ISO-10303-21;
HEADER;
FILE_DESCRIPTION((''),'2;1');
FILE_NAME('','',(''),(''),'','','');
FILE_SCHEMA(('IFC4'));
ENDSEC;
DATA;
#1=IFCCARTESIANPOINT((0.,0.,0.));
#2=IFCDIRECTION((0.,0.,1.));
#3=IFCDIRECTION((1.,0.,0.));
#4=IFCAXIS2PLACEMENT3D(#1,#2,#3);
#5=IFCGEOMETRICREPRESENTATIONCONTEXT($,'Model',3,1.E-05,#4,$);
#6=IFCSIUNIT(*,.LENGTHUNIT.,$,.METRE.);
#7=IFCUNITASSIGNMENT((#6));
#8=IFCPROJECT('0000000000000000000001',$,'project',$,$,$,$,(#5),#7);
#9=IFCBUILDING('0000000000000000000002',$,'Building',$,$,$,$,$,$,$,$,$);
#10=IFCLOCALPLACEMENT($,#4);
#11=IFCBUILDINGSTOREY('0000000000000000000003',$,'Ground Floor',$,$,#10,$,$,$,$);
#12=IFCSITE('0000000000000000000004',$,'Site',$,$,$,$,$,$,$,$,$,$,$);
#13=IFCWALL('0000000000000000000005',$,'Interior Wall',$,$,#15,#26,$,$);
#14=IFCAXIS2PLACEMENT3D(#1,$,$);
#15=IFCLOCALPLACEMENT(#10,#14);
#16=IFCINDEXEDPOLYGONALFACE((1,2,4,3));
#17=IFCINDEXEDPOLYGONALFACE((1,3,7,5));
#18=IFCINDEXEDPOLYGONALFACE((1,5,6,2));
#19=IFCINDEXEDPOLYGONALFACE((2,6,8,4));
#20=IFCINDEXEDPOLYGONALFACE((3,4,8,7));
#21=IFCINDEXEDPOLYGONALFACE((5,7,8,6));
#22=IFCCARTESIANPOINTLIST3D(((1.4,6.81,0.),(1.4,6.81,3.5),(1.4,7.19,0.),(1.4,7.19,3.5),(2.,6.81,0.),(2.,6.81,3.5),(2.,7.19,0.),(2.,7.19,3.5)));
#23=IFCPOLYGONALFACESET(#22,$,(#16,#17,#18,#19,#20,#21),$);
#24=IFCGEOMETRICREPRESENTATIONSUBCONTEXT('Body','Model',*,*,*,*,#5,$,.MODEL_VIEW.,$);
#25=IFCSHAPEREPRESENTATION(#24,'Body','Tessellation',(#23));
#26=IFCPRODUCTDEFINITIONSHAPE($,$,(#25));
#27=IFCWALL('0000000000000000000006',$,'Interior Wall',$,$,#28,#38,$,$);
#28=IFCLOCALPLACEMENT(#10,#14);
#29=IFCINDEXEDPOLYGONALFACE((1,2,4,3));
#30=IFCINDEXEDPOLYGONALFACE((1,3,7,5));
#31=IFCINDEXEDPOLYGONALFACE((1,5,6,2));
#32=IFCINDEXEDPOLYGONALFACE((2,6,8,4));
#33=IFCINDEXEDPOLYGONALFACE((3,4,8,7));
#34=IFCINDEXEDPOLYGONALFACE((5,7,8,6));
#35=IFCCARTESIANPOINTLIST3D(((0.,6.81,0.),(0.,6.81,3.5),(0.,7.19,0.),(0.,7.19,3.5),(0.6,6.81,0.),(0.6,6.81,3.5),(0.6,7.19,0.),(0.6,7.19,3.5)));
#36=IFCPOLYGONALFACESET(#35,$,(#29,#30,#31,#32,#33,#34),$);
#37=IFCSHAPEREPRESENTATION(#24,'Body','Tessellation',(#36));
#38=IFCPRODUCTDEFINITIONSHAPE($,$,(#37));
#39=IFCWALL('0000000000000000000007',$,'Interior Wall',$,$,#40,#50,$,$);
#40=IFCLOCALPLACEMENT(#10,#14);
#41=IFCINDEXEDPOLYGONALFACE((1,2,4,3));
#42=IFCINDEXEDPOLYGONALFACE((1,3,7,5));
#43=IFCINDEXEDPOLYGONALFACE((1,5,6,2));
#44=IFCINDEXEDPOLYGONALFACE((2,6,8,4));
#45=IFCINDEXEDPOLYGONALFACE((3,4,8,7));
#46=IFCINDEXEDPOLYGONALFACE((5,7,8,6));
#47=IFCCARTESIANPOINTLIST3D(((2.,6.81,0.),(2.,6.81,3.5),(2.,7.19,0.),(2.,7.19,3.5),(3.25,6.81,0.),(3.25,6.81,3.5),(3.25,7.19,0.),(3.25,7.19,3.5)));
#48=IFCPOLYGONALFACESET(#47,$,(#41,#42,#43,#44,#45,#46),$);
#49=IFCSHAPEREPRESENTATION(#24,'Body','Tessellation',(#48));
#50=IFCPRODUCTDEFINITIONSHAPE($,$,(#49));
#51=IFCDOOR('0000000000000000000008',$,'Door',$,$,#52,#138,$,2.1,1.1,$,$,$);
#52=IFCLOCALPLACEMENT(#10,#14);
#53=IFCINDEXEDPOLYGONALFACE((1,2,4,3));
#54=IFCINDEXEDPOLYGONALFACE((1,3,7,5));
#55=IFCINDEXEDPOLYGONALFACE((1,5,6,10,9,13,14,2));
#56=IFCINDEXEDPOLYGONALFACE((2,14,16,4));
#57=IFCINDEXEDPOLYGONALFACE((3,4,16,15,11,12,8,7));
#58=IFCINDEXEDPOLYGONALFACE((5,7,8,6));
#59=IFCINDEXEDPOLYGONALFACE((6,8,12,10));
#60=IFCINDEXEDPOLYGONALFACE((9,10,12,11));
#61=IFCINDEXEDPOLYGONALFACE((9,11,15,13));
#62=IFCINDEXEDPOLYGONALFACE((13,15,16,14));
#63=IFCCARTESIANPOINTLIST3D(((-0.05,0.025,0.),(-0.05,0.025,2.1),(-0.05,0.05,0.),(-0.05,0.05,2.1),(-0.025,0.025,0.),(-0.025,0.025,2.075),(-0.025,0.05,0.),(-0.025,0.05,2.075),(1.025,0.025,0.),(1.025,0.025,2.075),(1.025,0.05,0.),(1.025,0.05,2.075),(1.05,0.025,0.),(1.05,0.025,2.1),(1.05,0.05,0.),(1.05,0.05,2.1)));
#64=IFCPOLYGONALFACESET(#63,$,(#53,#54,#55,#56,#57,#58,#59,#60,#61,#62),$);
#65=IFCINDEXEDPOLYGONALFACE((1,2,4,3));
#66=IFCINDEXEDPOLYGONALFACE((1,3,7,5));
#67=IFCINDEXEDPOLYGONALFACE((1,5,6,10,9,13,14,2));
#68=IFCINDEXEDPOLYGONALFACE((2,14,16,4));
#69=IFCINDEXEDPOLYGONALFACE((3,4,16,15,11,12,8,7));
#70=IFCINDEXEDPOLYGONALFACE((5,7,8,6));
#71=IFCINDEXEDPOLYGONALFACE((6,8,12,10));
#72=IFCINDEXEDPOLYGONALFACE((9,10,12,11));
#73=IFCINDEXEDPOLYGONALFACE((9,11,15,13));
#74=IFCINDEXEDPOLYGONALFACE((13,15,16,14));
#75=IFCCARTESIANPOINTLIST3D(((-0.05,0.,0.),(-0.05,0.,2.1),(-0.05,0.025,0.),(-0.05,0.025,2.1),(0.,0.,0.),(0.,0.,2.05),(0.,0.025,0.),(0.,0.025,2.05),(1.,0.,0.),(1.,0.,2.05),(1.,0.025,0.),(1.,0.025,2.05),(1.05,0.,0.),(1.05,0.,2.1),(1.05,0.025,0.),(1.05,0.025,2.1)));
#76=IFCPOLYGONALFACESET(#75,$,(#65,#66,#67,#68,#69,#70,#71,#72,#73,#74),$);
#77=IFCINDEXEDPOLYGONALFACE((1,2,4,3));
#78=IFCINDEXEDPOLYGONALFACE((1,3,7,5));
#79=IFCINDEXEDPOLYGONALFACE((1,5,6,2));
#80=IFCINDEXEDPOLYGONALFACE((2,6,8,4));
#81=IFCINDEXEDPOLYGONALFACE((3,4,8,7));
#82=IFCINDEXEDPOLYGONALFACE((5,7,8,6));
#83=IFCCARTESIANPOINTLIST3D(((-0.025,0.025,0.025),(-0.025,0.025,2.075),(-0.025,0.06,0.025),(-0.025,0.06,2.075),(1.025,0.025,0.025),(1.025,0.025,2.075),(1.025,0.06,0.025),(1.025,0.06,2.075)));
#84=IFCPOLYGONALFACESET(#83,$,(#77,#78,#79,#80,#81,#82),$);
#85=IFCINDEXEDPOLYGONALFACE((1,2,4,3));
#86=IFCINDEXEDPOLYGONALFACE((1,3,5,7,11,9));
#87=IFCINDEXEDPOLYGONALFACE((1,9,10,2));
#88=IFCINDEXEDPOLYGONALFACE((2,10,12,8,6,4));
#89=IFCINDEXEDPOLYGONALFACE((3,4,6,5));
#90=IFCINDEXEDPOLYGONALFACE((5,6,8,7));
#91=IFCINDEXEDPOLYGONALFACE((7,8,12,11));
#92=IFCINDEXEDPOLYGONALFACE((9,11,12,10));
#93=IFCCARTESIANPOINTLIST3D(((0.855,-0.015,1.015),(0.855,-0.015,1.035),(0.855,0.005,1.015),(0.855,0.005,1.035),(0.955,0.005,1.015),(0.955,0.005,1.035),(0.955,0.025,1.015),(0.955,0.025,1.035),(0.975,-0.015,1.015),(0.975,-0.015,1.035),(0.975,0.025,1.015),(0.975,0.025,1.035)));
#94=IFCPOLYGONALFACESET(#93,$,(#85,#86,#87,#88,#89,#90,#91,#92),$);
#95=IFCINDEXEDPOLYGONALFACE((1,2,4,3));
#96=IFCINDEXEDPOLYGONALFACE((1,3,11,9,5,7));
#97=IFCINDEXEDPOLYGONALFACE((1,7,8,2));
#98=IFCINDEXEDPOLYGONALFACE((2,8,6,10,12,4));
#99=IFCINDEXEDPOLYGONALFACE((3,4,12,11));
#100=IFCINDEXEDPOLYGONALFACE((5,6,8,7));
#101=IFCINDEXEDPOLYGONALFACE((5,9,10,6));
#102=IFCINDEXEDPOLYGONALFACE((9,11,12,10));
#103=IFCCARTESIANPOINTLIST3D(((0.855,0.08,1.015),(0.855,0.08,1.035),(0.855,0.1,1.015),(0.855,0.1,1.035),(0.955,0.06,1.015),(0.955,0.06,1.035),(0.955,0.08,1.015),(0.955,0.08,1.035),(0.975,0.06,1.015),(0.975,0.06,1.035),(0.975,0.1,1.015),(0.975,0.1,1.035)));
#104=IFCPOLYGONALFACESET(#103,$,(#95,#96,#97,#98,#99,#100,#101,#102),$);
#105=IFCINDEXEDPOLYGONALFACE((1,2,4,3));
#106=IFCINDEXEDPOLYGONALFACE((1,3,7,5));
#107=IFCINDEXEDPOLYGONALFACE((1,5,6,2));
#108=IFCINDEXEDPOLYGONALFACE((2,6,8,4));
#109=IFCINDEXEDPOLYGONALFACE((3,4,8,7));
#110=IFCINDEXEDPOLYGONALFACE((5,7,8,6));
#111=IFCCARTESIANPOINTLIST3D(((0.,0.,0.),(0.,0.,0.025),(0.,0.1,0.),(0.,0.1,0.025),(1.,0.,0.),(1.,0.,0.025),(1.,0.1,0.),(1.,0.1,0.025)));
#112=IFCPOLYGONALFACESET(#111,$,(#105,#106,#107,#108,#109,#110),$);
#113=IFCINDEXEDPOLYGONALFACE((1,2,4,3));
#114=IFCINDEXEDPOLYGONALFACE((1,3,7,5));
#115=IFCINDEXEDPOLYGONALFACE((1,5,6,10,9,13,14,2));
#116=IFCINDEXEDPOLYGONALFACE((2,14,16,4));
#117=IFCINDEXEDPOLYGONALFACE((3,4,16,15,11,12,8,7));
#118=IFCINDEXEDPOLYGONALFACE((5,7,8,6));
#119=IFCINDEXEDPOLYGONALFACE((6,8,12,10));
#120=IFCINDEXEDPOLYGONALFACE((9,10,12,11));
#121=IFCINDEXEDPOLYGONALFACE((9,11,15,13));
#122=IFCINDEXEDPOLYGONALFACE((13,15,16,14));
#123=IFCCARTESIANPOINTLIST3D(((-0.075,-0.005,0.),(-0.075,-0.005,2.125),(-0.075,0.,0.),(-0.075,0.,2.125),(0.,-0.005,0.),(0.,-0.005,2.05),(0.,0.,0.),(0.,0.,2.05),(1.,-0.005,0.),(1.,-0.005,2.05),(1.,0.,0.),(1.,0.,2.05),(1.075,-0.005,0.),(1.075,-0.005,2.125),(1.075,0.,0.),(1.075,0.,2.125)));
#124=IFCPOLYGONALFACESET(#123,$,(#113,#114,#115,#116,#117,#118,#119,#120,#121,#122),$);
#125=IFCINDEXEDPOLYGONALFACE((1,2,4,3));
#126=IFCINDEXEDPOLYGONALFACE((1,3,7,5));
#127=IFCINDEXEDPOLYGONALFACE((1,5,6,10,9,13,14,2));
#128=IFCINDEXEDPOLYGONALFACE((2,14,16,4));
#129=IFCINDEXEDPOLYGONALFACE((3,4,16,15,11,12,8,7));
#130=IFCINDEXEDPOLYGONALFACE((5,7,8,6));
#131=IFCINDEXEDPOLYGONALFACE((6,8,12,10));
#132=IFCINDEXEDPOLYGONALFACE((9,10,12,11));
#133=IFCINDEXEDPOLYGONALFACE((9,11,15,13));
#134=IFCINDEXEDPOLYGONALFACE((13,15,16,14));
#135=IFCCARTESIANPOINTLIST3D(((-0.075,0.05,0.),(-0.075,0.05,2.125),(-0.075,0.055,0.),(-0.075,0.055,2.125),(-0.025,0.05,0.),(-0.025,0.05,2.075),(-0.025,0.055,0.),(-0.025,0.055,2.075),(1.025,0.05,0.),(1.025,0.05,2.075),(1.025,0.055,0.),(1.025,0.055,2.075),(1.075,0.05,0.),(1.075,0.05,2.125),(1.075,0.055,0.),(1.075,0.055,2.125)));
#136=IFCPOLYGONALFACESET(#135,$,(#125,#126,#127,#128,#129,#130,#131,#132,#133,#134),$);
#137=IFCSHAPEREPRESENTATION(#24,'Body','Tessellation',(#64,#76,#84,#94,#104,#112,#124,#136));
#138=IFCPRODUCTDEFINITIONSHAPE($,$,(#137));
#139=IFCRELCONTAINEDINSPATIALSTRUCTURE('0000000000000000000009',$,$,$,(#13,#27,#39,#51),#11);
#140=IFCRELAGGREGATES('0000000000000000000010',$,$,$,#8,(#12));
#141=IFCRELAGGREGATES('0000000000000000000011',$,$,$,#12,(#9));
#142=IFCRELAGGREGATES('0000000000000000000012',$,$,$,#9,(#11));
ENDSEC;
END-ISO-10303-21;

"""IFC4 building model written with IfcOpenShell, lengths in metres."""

from ifc_helpers import new_model, si_unit, frame, origin_with_axes, place, context, subcontext, project, spatial, line, indexed_curve, outline, extrude, element, save


model = new_model("IFC4")

# Units and contexts
model_context = context("Model", 3, precision=1e-05, world=origin_with_axes())
body_context = subcontext(model_context, "Body", "Model", "MODEL_VIEW")
ifc_project = project(units=[si_unit("LENGTHUNIT", "METRE")], contexts=[model_context])

# Site, building, storey
site = spatial("IfcSite", under=ifc_project, Name="Site")
building = spatial("IfcBuilding", under=site, Name="Building")
storey_placement = place(None, origin_with_axes())
storey = spatial("IfcBuildingStorey", under=building, at=storey_placement, Name="Ground Floor")

# Walls
for number, where, z_axis, x_axis, name in (
    (1, (2.0, 7.0, 0.0), (0.0, 0.0, 1.0), (-1.0, 0.0, 0.0), "Interior Wall"),
    (2, (0.6, 7.0, 0.0), (0.0, 0.0, 1.0), (-1.0, 0.0, 0.0), "Interior Wall"),
):
    element("IfcWall", number, at=place(storey_placement, frame(where, z_axis=z_axis, x_axis=x_axis)), inside=storey, Name=name, context=body_context, shape_type="SweptSolid", body=[
        extrude(outline(indexed_curve([(0.0, 0.0), (0.0, 0.38), (0.6, 0.38), (0.6, 0.0), (0.0, 0.0)], self_intersect=False)), frame((0.0, -0.19, 0.0), z_axis=(0.0, 0.0, 1.0), x_axis=(1.0, 0.0, 0.0)), (0.0, 0.0, 1.0), 3.5),
    ])
wall_1_placement = place(storey_placement, frame((3.25, 7.0, 0.0), z_axis=(0.0, 0.0, 1.0), x_axis=(-1.0, 0.0, 0.0)))
element("IfcWall", 3, at=wall_1_placement, inside=storey, Name="Interior Wall", context=body_context, shape_type="SweptSolid", body=[
    extrude(outline(indexed_curve([(0.0, 0.0), (0.0, 0.38), (1.25, 0.38), (1.25, 0.0), (0.0, 0.0)], self_intersect=False)), frame((0.0, -0.19, 0.0), z_axis=(0.0, 0.0, 1.0), x_axis=(1.0, 0.0, 0.0)), (0.0, 0.0, 1.0), 3.5),
])

# Door
door_1_placement = place(storey_placement, frame((-0.05, 0.0, 0.0), z_axis=(0.0, 0.0, 1.0), x_axis=(1.0, 0.0, 0.0)))
element("IfcDoor", 4, at=door_1_placement, inside=storey, Name="Door", OverallHeight=2.1, OverallWidth=1.1, context=body_context, shape_type="SweptSolid", body=[
    extrude(outline(indexed_curve([(0.0, 0.0), (0.0, 2.1), (1.1, 2.1), (1.1, 0.0), (1.075, 0.0), (1.075, 2.075), (0.025, 2.075), (0.025, 0.0)], segments=[line(1, 2, 3, 4, 5, 6, 7, 8, 1)])), frame((0.0, 0.025, 0.0), z_axis=(0.0, -1.0, 0.0), x_axis=(1.0, 0.0, 0.0)), (0.0, 0.0, -1.0), 0.025),
    extrude(outline(indexed_curve([(0.0, 0.0), (0.0, 2.1), (1.1, 2.1), (1.1, 0.0), (1.05, 0.0), (1.05, 2.05), (0.05, 2.05), (0.05, 0.0)], segments=[line(1, 2, 3, 4, 5, 6, 7, 8, 1)])), frame((0.0, 0.0, 0.0), z_axis=(0.0, -1.0, 0.0), x_axis=(1.0, 0.0, 0.0)), (0.0, 0.0, -1.0), 0.025),
    extrude(outline(indexed_curve([(0.0, 0.0), (1.05, 0.0), (1.05, 0.035), (0.0, 0.035)], segments=[line(1, 2, 3, 4, 1)])), frame((0.025, 0.025, 0.025), z_axis=(0.0, 0.0, 1.0), x_axis=(1.0, 0.0, 0.0)), (0.0, 0.0, 1.0), 2.05),
    extrude(outline(indexed_curve([(0.0, 0.0), (0.0, -0.04), (-0.12, -0.04), (-0.12, -0.02), (-0.02, -0.02), (-0.02, 0.0)], segments=[line(1, 2, 3, 4, 5, 6, 1)])), frame((1.025, 0.025, 1.015), z_axis=(0.0, 0.0, 1.0), x_axis=(1.0, 0.0, 0.0)), (0.0, 0.0, 1.0), 0.02),
    extrude(outline(indexed_curve([(0.0, 0.0), (0.0, 0.04), (-0.12, 0.04), (-0.12, 0.02), (-0.02, 0.02), (-0.02, 0.0)], segments=[line(1, 2, 3, 4, 5, 6, 1)])), frame((1.025, 0.06, 1.015), z_axis=(0.0, 0.0, 1.0), x_axis=(1.0, 0.0, 0.0)), (0.0, 0.0, 1.0), 0.02),
    extrude(outline(indexed_curve([(0.0, 0.0), (1.0, 0.0), (1.0, 0.1), (0.0, 0.1)], segments=[line(1, 2, 3, 4, 1)])), frame((0.05, 0.0, 0.0), z_axis=(0.0, 0.0, 1.0), x_axis=(1.0, 0.0, 0.0)), (0.0, 0.0, 1.0), 0.025),
    extrude(outline(indexed_curve([(0.0, 0.0), (0.0, 2.125), (1.15, 2.125), (1.15, 0.0), (1.075, 0.0), (1.075, 2.05), (0.075, 2.05), (0.075, 0.0)], segments=[line(1, 2, 3, 4, 5, 6, 7, 8, 1)])), frame((-0.025, -0.005, 0.0), z_axis=(0.0, -1.0, 0.0), x_axis=(1.0, 0.0, 0.0)), (0.0, 0.0, -1.0), 0.005),
    extrude(outline(indexed_curve([(0.0, 0.0), (0.0, 2.125), (1.15, 2.125), (1.15, 0.0), (1.1, 0.0), (1.1, 2.075), (0.05, 2.075), (0.05, 0.0)], segments=[line(1, 2, 3, 4, 5, 6, 7, 8, 1)])), frame((-0.025, 0.05, 0.0), z_axis=(0.0, -1.0, 0.0), x_axis=(1.0, 0.0, 0.0)), (0.0, 0.0, -1.0), 0.005),
])

save(model, "model.ifc")
